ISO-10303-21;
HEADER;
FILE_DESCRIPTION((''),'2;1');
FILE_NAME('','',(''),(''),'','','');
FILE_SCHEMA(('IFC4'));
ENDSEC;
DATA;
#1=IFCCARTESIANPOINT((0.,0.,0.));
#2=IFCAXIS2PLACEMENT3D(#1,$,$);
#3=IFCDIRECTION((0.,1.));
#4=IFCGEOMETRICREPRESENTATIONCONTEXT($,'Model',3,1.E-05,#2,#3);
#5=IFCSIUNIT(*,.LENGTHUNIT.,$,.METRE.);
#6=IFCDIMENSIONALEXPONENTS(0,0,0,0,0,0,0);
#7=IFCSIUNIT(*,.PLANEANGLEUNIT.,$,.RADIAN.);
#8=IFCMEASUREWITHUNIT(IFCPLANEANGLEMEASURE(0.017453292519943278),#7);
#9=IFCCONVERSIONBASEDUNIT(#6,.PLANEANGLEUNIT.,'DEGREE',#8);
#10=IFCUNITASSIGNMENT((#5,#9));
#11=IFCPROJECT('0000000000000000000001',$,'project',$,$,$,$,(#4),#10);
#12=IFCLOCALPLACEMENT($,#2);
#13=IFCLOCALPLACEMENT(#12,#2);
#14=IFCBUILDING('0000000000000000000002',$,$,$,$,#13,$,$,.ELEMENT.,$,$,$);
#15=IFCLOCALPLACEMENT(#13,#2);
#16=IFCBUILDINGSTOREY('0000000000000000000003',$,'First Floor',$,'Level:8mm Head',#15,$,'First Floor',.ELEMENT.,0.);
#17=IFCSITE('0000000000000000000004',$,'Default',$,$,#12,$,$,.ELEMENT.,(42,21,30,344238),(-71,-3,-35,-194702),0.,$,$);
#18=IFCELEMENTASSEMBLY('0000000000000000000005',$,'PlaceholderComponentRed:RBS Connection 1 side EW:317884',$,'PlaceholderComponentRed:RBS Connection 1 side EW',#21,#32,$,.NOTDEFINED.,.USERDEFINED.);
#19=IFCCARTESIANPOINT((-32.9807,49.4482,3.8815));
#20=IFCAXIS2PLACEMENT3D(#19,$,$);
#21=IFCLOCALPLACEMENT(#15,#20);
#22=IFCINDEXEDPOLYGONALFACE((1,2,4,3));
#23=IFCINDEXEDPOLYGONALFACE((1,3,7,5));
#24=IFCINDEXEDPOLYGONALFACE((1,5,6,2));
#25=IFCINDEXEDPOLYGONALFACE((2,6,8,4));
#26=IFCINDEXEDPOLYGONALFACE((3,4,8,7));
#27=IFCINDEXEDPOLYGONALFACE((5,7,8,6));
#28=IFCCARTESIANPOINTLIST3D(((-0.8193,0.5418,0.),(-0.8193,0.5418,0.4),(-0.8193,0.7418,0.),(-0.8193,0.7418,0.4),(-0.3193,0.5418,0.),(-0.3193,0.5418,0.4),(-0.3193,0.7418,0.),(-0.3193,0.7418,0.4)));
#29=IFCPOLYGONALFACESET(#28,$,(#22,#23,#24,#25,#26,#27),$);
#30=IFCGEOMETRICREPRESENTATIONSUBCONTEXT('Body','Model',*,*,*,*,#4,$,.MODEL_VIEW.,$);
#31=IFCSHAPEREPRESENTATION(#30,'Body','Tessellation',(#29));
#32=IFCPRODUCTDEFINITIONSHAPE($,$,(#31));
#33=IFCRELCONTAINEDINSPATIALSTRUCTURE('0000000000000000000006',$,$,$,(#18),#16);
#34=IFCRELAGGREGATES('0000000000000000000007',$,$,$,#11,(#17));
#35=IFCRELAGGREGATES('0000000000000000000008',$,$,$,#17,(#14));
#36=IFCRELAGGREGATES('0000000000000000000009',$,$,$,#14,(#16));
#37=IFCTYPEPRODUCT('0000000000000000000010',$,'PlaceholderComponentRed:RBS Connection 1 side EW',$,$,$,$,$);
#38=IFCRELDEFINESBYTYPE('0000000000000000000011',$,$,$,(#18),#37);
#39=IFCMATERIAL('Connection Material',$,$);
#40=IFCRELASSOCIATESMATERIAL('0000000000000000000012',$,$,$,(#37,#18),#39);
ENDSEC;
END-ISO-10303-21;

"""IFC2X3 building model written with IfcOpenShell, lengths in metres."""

from ifc_helpers import new_model, entity, si_unit, converted_unit, direction, frame, frame_2d, origin, place, context, subcontext, project, spatial, rectangle, extrude, source, transform, mapped, material, type_object, type_shapes, element, save


model = new_model("IFC2X3")

# Units and contexts
model_context = context("Model", 3, precision=1e-05, world=origin(), true_north=direction((0.0, 1.0)))
body_context = subcontext(model_context, "Body", "Model", "MODEL_VIEW")
ifc_project = project(units=[si_unit("LENGTHUNIT", "METRE"), converted_unit("PLANEANGLEUNIT", "DEGREE", entity("IfcPlaneAngleMeasure", 0.017453292519943278), si_unit("PLANEANGLEUNIT", "RADIAN"), dimensions=[0, 0, 0, 0, 0, 0, 0])], contexts=[model_context])

# Site, building, storey
site_placement = place(None, origin())
site = spatial("IfcSite", under=ifc_project, at=site_placement, Name="Default", CompositionType="ELEMENT", RefLatitude=(42, 21, 30, 344238), RefLongitude=(-71, -3, -35, -194702), RefElevation=0.0)
building_placement = place(site_placement, origin())
building = spatial("IfcBuilding", under=site, at=building_placement, CompositionType="ELEMENT")
storey_placement = place(building_placement, origin())
storey = spatial("IfcBuildingStorey", under=building, at=storey_placement, Name="First Floor", ObjectType="Level:8mm Head", LongName="First Floor", CompositionType="ELEMENT", Elevation=0.0)

# Element assembly
ifc_material_1 = material(Name="Connection Material")
type_product = type_object("IfcTypeProduct", Name="PlaceholderComponentRed:RBS Connection 1 side EW", material=ifc_material_1)
shared_shape_1 = source(origin(), body_context, "Body", "SweptSolid", [
    extrude(rectangle(XDim=0.2, YDim=0.5, at=frame_2d((0.0, 0.0), x_axis=(1.0, 0.0))), frame((-0.5693, 0.6418, 0.0), z_axis=(0.0, 0.0, 1.0), x_axis=(0.0, 1.0, 0.0)), (0.0, 0.0, 1.0), 0.4),
])
type_shapes(type_product, [shared_shape_1])
assembly_1_placement = place(storey_placement, frame((-32.9807, 49.4482, 3.8815)))
element("IfcElementAssembly", 1, at=assembly_1_placement, inside=storey, type_object=type_product, material=ifc_material_1, Name="PlaceholderComponentRed:RBS Connection 1 side EW:317884", ObjectType="PlaceholderComponentRed:RBS Connection 1 side EW", AssemblyPlace="NOTDEFINED", PredefinedType="USERDEFINED", context=body_context, shape_type="MappedRepresentation", body=[
    mapped(shared_shape_1, transform((0.0, 0.0, 0.0), scale=1.0)),
])

save(model, "model.ifc")
